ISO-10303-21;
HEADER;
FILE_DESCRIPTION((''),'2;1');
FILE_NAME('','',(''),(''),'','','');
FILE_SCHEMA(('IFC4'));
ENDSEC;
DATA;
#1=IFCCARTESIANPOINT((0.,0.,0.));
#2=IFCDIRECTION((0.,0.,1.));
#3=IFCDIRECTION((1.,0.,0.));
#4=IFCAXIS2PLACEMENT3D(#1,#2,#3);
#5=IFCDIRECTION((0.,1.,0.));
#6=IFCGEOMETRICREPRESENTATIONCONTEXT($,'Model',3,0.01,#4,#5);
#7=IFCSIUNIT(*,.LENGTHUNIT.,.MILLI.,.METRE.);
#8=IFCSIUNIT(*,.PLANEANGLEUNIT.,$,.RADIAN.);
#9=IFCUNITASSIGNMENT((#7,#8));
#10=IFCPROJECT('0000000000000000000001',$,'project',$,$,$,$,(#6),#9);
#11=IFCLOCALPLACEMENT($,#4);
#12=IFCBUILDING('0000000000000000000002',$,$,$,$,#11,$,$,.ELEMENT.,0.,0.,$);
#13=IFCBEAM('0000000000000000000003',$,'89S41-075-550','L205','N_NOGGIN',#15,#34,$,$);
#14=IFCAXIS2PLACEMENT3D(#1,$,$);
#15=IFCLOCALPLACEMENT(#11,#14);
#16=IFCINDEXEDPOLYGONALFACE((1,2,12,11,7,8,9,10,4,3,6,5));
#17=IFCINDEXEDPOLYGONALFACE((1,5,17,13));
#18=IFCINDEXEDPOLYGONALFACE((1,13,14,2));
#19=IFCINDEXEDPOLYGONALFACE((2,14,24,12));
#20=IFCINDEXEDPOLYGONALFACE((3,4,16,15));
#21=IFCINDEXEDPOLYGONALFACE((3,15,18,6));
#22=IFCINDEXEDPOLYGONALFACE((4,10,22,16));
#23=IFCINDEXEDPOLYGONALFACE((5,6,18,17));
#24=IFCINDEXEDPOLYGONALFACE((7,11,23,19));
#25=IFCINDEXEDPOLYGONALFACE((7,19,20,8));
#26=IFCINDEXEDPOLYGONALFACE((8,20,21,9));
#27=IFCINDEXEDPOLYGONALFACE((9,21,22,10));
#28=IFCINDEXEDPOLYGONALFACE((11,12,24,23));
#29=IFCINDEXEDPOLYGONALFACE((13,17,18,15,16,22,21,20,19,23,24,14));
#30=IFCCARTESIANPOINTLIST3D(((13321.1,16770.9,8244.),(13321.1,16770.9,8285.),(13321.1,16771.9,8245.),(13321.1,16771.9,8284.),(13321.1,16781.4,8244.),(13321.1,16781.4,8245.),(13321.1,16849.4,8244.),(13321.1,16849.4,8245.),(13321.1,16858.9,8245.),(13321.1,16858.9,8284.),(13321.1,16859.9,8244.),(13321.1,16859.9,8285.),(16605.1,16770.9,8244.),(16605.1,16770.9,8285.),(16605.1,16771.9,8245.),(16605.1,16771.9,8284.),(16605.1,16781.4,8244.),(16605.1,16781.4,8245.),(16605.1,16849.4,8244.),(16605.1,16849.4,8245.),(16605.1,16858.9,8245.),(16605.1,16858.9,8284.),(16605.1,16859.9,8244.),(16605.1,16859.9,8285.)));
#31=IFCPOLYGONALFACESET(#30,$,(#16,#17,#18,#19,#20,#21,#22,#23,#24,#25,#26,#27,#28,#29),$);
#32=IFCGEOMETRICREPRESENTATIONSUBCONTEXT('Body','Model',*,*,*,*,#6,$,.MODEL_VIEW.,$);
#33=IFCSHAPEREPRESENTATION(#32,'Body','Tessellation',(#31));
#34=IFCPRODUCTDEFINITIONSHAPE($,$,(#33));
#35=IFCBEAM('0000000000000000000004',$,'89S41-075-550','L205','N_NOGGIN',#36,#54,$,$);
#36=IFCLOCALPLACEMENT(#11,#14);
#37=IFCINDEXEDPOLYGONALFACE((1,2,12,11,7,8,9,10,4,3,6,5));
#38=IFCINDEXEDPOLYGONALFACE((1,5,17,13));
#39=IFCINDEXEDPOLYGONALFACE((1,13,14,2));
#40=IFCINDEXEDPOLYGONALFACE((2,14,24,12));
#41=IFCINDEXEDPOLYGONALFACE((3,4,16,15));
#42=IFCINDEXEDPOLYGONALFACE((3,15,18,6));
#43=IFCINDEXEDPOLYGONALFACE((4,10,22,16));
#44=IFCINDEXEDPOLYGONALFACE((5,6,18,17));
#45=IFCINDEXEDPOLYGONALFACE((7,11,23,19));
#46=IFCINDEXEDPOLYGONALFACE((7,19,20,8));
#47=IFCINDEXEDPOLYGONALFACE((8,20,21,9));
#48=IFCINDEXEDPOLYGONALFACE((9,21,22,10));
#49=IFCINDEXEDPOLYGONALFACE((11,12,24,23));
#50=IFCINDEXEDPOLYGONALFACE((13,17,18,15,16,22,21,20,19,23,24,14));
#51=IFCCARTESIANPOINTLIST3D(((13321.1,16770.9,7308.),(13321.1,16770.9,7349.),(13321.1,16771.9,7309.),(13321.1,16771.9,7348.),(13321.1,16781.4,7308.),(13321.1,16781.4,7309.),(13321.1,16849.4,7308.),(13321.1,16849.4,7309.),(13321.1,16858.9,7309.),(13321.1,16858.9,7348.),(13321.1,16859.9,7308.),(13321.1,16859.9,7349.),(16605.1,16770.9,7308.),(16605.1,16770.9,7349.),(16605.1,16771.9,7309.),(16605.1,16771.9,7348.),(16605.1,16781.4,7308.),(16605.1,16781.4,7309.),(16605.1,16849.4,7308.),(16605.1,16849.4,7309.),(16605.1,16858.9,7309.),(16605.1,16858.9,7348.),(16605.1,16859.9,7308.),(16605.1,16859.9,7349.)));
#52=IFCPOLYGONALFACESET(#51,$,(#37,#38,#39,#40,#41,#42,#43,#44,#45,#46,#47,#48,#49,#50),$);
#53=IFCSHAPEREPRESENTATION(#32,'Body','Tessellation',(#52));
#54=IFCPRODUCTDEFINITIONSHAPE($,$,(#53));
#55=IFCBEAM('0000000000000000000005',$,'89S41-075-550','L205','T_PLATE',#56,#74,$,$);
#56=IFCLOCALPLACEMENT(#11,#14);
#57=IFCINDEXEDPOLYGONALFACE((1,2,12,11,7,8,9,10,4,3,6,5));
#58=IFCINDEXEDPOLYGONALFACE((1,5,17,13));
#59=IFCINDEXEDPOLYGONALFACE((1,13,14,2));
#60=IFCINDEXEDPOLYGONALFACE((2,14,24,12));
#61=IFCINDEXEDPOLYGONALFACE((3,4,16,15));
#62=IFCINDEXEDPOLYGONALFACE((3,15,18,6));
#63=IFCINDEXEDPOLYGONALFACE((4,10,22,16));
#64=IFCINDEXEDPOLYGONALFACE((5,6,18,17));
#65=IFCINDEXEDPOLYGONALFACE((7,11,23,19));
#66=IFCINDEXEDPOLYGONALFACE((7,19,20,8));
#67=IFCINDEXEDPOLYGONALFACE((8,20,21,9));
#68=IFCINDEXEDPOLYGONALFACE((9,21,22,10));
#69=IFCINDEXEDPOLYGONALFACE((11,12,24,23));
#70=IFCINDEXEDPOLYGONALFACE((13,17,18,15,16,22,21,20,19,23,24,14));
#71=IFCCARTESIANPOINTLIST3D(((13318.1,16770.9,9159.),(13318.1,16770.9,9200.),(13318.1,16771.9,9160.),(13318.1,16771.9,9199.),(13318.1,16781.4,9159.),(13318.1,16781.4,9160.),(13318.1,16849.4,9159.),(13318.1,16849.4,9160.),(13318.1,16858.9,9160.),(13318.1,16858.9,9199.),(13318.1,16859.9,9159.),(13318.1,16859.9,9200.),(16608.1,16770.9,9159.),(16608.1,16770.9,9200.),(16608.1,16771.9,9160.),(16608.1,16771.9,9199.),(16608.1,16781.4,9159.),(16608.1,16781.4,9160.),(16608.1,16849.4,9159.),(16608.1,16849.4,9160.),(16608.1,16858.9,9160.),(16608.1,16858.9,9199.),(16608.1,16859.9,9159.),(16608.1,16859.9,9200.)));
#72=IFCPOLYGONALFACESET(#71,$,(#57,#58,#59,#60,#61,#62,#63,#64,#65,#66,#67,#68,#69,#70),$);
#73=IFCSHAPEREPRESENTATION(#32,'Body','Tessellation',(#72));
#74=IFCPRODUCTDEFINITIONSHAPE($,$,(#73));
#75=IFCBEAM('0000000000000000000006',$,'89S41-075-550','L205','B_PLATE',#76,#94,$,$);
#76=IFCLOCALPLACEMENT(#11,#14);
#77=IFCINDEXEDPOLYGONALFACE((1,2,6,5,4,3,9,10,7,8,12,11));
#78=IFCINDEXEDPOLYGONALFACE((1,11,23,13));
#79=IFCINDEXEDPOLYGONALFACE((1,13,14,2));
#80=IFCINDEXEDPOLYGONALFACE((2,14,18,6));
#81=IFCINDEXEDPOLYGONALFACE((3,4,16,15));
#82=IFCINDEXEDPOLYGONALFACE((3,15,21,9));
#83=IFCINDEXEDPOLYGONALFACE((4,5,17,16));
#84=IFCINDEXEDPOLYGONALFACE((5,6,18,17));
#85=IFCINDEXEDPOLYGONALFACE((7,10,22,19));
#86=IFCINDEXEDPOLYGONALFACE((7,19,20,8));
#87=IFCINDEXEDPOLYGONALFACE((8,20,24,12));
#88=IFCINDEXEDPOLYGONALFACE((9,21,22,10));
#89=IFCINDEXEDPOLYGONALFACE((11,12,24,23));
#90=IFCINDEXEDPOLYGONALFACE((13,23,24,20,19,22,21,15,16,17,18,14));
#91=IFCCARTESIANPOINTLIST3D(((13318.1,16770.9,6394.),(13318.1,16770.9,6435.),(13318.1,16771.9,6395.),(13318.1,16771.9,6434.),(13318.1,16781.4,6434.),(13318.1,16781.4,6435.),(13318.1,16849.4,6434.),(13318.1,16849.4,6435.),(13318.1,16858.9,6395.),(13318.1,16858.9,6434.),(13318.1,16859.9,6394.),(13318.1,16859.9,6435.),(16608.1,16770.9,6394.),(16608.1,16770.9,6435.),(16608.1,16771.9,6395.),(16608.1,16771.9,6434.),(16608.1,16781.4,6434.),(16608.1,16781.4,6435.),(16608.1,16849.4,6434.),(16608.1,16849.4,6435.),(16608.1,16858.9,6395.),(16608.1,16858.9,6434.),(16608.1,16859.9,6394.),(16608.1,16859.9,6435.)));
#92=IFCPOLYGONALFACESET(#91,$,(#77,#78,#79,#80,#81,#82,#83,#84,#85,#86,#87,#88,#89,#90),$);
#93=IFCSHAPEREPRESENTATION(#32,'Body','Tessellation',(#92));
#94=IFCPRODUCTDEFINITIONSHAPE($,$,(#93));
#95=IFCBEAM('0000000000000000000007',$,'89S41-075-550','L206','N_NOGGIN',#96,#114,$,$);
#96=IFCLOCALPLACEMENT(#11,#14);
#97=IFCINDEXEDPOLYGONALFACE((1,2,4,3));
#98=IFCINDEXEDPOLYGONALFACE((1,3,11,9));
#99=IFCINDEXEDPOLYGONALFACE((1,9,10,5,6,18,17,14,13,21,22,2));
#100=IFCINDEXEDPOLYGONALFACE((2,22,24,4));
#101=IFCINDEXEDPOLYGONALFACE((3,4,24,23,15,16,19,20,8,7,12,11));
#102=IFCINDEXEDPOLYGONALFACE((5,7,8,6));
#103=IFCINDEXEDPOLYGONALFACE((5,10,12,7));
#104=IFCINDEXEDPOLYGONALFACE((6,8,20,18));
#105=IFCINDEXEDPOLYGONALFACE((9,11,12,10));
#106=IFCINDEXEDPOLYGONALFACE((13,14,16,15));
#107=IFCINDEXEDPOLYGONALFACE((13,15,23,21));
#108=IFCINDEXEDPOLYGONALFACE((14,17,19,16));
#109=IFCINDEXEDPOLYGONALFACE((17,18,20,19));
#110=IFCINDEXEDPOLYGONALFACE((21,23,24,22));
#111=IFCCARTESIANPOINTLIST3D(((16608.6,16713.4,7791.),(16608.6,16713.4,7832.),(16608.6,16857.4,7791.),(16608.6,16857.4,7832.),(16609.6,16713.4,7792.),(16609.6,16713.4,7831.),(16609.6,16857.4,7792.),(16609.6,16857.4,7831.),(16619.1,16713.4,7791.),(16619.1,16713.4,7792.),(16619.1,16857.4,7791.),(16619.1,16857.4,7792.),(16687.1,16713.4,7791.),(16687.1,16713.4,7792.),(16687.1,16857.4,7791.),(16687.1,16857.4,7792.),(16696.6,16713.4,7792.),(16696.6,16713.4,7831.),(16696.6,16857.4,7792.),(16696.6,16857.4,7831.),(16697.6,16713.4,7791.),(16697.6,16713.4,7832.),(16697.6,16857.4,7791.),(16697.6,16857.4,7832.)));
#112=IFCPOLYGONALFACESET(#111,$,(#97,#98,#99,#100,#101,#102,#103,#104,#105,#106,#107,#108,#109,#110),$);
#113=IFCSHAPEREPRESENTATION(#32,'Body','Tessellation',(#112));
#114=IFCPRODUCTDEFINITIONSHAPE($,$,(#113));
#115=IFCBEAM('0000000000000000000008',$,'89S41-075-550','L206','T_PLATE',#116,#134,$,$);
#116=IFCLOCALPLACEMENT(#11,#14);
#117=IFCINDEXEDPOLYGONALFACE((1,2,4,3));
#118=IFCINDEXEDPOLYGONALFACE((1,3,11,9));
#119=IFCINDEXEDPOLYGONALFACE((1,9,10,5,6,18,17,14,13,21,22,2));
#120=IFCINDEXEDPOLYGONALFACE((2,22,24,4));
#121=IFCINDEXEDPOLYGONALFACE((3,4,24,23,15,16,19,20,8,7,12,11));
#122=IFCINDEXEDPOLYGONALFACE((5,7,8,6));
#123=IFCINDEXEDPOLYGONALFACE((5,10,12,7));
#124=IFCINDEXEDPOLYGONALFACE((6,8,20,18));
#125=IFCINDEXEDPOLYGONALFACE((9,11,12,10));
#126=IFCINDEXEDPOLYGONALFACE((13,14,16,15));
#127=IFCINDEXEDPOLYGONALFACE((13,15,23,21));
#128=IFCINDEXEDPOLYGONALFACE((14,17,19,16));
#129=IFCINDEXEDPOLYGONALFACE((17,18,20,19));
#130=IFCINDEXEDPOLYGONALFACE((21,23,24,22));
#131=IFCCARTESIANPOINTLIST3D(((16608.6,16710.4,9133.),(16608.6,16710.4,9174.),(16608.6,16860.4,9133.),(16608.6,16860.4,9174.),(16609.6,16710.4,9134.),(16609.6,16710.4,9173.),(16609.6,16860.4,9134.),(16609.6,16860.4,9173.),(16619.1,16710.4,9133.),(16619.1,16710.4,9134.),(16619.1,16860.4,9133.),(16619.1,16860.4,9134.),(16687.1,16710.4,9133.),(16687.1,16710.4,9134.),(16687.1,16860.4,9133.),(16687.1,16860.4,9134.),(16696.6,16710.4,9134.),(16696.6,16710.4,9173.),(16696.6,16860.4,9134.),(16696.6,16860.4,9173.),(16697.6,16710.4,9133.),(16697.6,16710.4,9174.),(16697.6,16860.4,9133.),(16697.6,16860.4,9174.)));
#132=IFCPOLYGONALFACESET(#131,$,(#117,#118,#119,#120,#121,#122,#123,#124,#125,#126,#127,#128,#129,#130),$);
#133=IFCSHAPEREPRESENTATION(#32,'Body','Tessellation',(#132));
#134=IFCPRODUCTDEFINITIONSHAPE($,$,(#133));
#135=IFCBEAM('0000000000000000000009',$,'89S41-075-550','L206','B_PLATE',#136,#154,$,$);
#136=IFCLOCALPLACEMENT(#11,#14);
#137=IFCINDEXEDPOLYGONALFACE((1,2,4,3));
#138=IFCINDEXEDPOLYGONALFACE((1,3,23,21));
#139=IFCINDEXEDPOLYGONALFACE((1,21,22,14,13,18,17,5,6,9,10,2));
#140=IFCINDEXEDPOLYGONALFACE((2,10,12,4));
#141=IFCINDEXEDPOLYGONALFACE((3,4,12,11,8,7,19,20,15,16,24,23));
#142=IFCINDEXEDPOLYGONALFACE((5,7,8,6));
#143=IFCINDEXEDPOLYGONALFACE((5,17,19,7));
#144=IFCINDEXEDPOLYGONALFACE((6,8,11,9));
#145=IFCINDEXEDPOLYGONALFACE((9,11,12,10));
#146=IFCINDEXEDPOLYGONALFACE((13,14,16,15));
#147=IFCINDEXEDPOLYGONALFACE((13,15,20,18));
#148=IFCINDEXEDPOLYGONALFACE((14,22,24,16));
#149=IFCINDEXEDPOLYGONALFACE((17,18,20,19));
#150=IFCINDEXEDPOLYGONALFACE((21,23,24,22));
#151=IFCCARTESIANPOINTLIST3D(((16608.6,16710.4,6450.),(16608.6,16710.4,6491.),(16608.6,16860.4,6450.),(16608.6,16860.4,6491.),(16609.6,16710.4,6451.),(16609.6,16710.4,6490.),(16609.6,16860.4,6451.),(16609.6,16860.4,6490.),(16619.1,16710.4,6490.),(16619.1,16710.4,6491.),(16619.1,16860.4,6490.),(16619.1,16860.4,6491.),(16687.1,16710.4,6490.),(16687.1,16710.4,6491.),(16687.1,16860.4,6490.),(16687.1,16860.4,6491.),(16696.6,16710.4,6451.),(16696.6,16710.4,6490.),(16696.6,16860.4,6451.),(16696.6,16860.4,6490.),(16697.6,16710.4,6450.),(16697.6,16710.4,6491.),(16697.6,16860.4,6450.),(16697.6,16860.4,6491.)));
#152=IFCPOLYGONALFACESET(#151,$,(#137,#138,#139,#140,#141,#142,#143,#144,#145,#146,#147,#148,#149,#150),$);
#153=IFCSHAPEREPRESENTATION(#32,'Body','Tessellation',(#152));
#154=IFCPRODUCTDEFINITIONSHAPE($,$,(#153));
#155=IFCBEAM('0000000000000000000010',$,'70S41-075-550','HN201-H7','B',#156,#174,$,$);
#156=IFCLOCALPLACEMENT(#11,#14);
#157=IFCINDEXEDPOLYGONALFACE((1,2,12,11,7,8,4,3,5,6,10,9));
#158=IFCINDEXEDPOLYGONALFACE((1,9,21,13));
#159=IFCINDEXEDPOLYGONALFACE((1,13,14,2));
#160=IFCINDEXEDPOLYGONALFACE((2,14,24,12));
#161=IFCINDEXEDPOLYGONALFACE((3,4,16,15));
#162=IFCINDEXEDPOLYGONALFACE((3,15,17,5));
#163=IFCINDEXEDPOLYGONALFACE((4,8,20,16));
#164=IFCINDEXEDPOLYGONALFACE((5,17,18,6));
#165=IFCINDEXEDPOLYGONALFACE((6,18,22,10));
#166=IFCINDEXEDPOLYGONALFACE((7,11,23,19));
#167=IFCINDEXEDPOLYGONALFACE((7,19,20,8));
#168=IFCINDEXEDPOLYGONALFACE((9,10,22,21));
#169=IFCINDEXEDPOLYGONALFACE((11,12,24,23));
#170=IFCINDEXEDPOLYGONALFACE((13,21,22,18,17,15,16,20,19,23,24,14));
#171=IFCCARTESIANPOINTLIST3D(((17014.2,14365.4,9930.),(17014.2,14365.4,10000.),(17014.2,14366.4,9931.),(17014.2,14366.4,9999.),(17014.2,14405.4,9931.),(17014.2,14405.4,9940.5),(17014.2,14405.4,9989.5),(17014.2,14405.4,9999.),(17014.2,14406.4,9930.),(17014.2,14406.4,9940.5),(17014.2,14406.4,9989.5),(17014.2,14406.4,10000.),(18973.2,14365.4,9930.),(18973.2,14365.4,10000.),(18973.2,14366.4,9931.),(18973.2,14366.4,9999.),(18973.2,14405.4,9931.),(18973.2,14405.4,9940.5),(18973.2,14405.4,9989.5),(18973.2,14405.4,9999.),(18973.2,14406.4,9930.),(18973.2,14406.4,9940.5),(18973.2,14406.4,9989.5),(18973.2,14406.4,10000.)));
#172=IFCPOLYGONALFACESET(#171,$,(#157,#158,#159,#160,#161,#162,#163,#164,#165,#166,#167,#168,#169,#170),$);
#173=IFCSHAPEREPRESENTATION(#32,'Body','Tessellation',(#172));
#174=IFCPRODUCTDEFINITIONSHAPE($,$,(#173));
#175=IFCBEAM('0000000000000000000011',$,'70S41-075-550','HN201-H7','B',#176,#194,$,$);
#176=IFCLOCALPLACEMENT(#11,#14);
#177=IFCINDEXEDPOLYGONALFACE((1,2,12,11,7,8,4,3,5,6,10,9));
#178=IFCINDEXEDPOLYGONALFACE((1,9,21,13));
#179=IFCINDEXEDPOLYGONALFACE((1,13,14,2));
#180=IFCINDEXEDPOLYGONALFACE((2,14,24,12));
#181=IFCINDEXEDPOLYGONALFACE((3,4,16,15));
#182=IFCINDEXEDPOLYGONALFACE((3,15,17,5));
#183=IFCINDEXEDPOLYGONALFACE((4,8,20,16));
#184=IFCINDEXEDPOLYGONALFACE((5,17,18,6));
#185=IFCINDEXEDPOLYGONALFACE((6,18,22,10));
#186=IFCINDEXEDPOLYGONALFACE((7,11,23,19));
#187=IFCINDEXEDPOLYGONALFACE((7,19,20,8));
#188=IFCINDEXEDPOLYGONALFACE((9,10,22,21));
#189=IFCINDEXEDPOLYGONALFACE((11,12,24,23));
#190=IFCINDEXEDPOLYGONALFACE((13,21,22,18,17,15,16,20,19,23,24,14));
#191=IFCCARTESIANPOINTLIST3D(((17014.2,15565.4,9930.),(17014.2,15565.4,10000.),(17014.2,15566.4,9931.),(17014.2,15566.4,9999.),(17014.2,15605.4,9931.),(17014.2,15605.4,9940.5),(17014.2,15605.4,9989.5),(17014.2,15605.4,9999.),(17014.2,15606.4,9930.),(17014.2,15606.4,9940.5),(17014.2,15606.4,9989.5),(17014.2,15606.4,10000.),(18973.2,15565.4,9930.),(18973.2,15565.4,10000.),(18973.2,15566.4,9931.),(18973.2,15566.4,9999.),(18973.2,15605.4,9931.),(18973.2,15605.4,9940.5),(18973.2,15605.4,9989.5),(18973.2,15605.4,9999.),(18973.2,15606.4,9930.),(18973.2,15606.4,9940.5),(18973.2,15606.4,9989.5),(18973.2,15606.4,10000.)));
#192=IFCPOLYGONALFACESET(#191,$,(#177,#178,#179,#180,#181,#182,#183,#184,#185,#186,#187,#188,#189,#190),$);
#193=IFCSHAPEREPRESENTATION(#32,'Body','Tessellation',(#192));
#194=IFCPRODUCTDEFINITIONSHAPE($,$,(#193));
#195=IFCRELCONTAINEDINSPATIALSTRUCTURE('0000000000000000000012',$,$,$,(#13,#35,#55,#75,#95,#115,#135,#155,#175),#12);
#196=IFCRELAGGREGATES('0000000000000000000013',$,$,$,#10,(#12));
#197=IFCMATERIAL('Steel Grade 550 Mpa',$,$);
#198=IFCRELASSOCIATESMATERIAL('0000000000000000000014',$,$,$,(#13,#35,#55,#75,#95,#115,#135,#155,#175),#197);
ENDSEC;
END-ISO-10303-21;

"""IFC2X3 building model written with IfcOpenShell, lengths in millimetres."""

from ifc_helpers import new_model, si_unit, direction, frame, origin, origin_with_axes, origin_2d_with_axis, place, context, subcontext, project, spatial, c_section, extrude, source, transform, mapped, material, element, save


model = new_model("IFC2X3")

# Units and contexts
model_context = context("Model", 3, precision=0.01, world=origin_with_axes(), true_north=direction((0.0, 1.0, 0.0)))
body_context = subcontext(model_context, "Body", "Model", "MODEL_VIEW")
ifc_project = project(units=[si_unit("LENGTHUNIT", "METRE", prefix="MILLI"), si_unit("PLANEANGLEUNIT", "RADIAN")], contexts=[model_context])

# Building
building_placement = place(None, origin_with_axes())
building = spatial("IfcBuilding", under=ifc_project, at=building_placement, CompositionType="ELEMENT", ElevationOfRefHeight=0.0, ElevationOfTerrain=0.0)

# Shared definitions
ifc_material = material(Name="Steel Grade 550 Mpa")

# Beams
shared_shape_1 = source(origin(), body_context, "Body", "SweptSolid", [
    extrude(c_section(Depth=89.0, Width=41.0, WallThickness=1.0, Girth=10.5, at=origin_2d_with_axis()), origin_with_axes(), (0.0, 0.0, 1.0), 3284.0),
])
beam_1_placement = place(None, frame((16605.1, 16815.4, 8264.5), z_axis=(-1.0, 0.0, 0.0), x_axis=(0.0, 0.0, -1.0)))
element("IfcBeam", 1, at=beam_1_placement, inside=building, material=ifc_material, Name="89S41-075-550", Description="L205", ObjectType="N_NOGGIN", context=body_context, shape_type="MappedRepresentation", body=[
    mapped(shared_shape_1, transform((0.0, 0.0, 0.0), scale=1.0)),
])
shared_shape_2 = source(origin(), body_context, "Body", "SweptSolid", [
    extrude(c_section(Depth=89.0, Width=41.0, WallThickness=1.0, Girth=10.5, at=origin_2d_with_axis()), origin_with_axes(), (0.0, 0.0, 1.0), 3284.0),
])
beam_2_placement = place(None, frame((16605.1, 16815.4, 7328.5), z_axis=(-1.0, 0.0, 0.0), x_axis=(0.0, 0.0, -1.0)))
element("IfcBeam", 2, at=beam_2_placement, inside=building, material=ifc_material, Name="89S41-075-550", Description="L205", ObjectType="N_NOGGIN", context=body_context, shape_type="MappedRepresentation", body=[
    mapped(shared_shape_2, transform((0.0, 0.0, 0.0), scale=1.0)),
])
shared_shape_3 = source(origin(), body_context, "Body", "SweptSolid", [
    extrude(c_section(Depth=89.0, Width=41.0, WallThickness=1.0, Girth=10.5, at=origin_2d_with_axis()), origin_with_axes(), (0.0, 0.0, 1.0), 3290.0),
])
beam_3_placement = place(None, frame((16608.1, 16815.4, 9179.5), z_axis=(-1.0, 0.0, 0.0), x_axis=(0.0, 0.0, -1.0)))
element("IfcBeam", 3, at=beam_3_placement, inside=building, material=ifc_material, Name="89S41-075-550", Description="L205", ObjectType="T_PLATE", context=body_context, shape_type="MappedRepresentation", body=[
    mapped(shared_shape_3, transform((0.0, 0.0, 0.0), scale=1.0)),
])
shared_shape_4 = source(origin(), body_context, "Body", "SweptSolid", [
    extrude(c_section(Depth=89.0, Width=41.0, WallThickness=1.0, Girth=10.5, at=origin_2d_with_axis()), origin_with_axes(), (0.0, 0.0, 1.0), 3290.0),
])
beam_4_placement = place(None, frame((16608.1, 16815.4, 6414.5), z_axis=(-1.0, 0.0, 0.0), x_axis=(0.0, 0.0, 1.0)))
element("IfcBeam", 4, at=beam_4_placement, inside=building, material=ifc_material, Name="89S41-075-550", Description="L205", ObjectType="B_PLATE", context=body_context, shape_type="MappedRepresentation", body=[
    mapped(shared_shape_4, transform((0.0, 0.0, 0.0), scale=1.0)),
])
shared_shape_5 = source(origin(), body_context, "Body", "SweptSolid", [
    extrude(c_section(Depth=89.0, Width=41.0, WallThickness=1.0, Girth=10.5, at=origin_2d_with_axis()), origin_with_axes(), (0.0, 0.0, 1.0), 144.0),
])
beam_5_placement = place(None, frame((16653.1, 16857.4, 7811.5), z_axis=(0.0, -1.0, 0.0), x_axis=(0.0, 0.0, -1.0)))
element("IfcBeam", 5, at=beam_5_placement, inside=building, material=ifc_material, Name="89S41-075-550", Description="L206", ObjectType="N_NOGGIN", context=body_context, shape_type="MappedRepresentation", body=[
    mapped(shared_shape_5, transform((0.0, 0.0, 0.0), scale=1.0)),
])
shared_shape_6 = source(origin(), body_context, "Body", "SweptSolid", [
    extrude(c_section(Depth=89.0, Width=41.0, WallThickness=1.0, Girth=10.5, at=origin_2d_with_axis()), origin_with_axes(), (0.0, 0.0, 1.0), 150.0),
])
beam_6_placement = place(None, frame((16653.1, 16860.4, 9153.5), z_axis=(0.0, -1.0, 0.0), x_axis=(0.0, 0.0, -1.0)))
element("IfcBeam", 6, at=beam_6_placement, inside=building, material=ifc_material, Name="89S41-075-550", Description="L206", ObjectType="T_PLATE", context=body_context, shape_type="MappedRepresentation", body=[
    mapped(shared_shape_6, transform((0.0, 0.0, 0.0), scale=1.0)),
])
shared_shape_7 = source(origin(), body_context, "Body", "SweptSolid", [
    extrude(c_section(Depth=89.0, Width=41.0, WallThickness=1.0, Girth=10.5, at=origin_2d_with_axis()), origin_with_axes(), (0.0, 0.0, 1.0), 150.0),
])
beam_7_placement = place(None, frame((16653.1, 16860.4, 6470.5), z_axis=(0.0, -1.0, 0.0), x_axis=(0.0, 0.0, 1.0)))
element("IfcBeam", 7, at=beam_7_placement, inside=building, material=ifc_material, Name="89S41-075-550", Description="L206", ObjectType="B_PLATE", context=body_context, shape_type="MappedRepresentation", body=[
    mapped(shared_shape_7, transform((0.0, 0.0, 0.0), scale=1.0)),
])
shared_shape_8 = source(origin(), body_context, "Body", "SweptSolid", [
    extrude(c_section(Depth=70.0, Width=41.0, WallThickness=1.0, Girth=10.5, at=origin_2d_with_axis()), origin_with_axes(), (0.0, 0.0, 1.0), 1959.1),
])
beam_8_placement = place(None, frame((17014.2, 14385.9, 9965.0), z_axis=(1.0, 0.0, 0.0), x_axis=(0.0, 1.0, 0.0)))
element("IfcBeam", 8, at=beam_8_placement, inside=building, material=ifc_material, Name="70S41-075-550", Description="HN201-H7", ObjectType="B", context=body_context, shape_type="MappedRepresentation", body=[
    mapped(shared_shape_8, transform((0.0, 0.0, 0.0), scale=1.0)),
])
shared_shape_9 = source(origin(), body_context, "Body", "SweptSolid", [
    extrude(c_section(Depth=70.0, Width=41.0, WallThickness=1.0, Girth=10.5, at=origin_2d_with_axis()), origin_with_axes(), (0.0, 0.0, 1.0), 1959.1),
])
beam_9_placement = place(None, frame((17014.2, 15585.9, 9965.0), z_axis=(1.0, 0.0, 0.0), x_axis=(0.0, 1.0, 0.0)))
element("IfcBeam", 9, at=beam_9_placement, inside=building, material=ifc_material, Name="70S41-075-550", Description="HN201-H7", ObjectType="B", context=body_context, shape_type="MappedRepresentation", body=[
    mapped(shared_shape_9, transform((0.0, 0.0, 0.0), scale=1.0)),
])

save(model, "model.ifc")
